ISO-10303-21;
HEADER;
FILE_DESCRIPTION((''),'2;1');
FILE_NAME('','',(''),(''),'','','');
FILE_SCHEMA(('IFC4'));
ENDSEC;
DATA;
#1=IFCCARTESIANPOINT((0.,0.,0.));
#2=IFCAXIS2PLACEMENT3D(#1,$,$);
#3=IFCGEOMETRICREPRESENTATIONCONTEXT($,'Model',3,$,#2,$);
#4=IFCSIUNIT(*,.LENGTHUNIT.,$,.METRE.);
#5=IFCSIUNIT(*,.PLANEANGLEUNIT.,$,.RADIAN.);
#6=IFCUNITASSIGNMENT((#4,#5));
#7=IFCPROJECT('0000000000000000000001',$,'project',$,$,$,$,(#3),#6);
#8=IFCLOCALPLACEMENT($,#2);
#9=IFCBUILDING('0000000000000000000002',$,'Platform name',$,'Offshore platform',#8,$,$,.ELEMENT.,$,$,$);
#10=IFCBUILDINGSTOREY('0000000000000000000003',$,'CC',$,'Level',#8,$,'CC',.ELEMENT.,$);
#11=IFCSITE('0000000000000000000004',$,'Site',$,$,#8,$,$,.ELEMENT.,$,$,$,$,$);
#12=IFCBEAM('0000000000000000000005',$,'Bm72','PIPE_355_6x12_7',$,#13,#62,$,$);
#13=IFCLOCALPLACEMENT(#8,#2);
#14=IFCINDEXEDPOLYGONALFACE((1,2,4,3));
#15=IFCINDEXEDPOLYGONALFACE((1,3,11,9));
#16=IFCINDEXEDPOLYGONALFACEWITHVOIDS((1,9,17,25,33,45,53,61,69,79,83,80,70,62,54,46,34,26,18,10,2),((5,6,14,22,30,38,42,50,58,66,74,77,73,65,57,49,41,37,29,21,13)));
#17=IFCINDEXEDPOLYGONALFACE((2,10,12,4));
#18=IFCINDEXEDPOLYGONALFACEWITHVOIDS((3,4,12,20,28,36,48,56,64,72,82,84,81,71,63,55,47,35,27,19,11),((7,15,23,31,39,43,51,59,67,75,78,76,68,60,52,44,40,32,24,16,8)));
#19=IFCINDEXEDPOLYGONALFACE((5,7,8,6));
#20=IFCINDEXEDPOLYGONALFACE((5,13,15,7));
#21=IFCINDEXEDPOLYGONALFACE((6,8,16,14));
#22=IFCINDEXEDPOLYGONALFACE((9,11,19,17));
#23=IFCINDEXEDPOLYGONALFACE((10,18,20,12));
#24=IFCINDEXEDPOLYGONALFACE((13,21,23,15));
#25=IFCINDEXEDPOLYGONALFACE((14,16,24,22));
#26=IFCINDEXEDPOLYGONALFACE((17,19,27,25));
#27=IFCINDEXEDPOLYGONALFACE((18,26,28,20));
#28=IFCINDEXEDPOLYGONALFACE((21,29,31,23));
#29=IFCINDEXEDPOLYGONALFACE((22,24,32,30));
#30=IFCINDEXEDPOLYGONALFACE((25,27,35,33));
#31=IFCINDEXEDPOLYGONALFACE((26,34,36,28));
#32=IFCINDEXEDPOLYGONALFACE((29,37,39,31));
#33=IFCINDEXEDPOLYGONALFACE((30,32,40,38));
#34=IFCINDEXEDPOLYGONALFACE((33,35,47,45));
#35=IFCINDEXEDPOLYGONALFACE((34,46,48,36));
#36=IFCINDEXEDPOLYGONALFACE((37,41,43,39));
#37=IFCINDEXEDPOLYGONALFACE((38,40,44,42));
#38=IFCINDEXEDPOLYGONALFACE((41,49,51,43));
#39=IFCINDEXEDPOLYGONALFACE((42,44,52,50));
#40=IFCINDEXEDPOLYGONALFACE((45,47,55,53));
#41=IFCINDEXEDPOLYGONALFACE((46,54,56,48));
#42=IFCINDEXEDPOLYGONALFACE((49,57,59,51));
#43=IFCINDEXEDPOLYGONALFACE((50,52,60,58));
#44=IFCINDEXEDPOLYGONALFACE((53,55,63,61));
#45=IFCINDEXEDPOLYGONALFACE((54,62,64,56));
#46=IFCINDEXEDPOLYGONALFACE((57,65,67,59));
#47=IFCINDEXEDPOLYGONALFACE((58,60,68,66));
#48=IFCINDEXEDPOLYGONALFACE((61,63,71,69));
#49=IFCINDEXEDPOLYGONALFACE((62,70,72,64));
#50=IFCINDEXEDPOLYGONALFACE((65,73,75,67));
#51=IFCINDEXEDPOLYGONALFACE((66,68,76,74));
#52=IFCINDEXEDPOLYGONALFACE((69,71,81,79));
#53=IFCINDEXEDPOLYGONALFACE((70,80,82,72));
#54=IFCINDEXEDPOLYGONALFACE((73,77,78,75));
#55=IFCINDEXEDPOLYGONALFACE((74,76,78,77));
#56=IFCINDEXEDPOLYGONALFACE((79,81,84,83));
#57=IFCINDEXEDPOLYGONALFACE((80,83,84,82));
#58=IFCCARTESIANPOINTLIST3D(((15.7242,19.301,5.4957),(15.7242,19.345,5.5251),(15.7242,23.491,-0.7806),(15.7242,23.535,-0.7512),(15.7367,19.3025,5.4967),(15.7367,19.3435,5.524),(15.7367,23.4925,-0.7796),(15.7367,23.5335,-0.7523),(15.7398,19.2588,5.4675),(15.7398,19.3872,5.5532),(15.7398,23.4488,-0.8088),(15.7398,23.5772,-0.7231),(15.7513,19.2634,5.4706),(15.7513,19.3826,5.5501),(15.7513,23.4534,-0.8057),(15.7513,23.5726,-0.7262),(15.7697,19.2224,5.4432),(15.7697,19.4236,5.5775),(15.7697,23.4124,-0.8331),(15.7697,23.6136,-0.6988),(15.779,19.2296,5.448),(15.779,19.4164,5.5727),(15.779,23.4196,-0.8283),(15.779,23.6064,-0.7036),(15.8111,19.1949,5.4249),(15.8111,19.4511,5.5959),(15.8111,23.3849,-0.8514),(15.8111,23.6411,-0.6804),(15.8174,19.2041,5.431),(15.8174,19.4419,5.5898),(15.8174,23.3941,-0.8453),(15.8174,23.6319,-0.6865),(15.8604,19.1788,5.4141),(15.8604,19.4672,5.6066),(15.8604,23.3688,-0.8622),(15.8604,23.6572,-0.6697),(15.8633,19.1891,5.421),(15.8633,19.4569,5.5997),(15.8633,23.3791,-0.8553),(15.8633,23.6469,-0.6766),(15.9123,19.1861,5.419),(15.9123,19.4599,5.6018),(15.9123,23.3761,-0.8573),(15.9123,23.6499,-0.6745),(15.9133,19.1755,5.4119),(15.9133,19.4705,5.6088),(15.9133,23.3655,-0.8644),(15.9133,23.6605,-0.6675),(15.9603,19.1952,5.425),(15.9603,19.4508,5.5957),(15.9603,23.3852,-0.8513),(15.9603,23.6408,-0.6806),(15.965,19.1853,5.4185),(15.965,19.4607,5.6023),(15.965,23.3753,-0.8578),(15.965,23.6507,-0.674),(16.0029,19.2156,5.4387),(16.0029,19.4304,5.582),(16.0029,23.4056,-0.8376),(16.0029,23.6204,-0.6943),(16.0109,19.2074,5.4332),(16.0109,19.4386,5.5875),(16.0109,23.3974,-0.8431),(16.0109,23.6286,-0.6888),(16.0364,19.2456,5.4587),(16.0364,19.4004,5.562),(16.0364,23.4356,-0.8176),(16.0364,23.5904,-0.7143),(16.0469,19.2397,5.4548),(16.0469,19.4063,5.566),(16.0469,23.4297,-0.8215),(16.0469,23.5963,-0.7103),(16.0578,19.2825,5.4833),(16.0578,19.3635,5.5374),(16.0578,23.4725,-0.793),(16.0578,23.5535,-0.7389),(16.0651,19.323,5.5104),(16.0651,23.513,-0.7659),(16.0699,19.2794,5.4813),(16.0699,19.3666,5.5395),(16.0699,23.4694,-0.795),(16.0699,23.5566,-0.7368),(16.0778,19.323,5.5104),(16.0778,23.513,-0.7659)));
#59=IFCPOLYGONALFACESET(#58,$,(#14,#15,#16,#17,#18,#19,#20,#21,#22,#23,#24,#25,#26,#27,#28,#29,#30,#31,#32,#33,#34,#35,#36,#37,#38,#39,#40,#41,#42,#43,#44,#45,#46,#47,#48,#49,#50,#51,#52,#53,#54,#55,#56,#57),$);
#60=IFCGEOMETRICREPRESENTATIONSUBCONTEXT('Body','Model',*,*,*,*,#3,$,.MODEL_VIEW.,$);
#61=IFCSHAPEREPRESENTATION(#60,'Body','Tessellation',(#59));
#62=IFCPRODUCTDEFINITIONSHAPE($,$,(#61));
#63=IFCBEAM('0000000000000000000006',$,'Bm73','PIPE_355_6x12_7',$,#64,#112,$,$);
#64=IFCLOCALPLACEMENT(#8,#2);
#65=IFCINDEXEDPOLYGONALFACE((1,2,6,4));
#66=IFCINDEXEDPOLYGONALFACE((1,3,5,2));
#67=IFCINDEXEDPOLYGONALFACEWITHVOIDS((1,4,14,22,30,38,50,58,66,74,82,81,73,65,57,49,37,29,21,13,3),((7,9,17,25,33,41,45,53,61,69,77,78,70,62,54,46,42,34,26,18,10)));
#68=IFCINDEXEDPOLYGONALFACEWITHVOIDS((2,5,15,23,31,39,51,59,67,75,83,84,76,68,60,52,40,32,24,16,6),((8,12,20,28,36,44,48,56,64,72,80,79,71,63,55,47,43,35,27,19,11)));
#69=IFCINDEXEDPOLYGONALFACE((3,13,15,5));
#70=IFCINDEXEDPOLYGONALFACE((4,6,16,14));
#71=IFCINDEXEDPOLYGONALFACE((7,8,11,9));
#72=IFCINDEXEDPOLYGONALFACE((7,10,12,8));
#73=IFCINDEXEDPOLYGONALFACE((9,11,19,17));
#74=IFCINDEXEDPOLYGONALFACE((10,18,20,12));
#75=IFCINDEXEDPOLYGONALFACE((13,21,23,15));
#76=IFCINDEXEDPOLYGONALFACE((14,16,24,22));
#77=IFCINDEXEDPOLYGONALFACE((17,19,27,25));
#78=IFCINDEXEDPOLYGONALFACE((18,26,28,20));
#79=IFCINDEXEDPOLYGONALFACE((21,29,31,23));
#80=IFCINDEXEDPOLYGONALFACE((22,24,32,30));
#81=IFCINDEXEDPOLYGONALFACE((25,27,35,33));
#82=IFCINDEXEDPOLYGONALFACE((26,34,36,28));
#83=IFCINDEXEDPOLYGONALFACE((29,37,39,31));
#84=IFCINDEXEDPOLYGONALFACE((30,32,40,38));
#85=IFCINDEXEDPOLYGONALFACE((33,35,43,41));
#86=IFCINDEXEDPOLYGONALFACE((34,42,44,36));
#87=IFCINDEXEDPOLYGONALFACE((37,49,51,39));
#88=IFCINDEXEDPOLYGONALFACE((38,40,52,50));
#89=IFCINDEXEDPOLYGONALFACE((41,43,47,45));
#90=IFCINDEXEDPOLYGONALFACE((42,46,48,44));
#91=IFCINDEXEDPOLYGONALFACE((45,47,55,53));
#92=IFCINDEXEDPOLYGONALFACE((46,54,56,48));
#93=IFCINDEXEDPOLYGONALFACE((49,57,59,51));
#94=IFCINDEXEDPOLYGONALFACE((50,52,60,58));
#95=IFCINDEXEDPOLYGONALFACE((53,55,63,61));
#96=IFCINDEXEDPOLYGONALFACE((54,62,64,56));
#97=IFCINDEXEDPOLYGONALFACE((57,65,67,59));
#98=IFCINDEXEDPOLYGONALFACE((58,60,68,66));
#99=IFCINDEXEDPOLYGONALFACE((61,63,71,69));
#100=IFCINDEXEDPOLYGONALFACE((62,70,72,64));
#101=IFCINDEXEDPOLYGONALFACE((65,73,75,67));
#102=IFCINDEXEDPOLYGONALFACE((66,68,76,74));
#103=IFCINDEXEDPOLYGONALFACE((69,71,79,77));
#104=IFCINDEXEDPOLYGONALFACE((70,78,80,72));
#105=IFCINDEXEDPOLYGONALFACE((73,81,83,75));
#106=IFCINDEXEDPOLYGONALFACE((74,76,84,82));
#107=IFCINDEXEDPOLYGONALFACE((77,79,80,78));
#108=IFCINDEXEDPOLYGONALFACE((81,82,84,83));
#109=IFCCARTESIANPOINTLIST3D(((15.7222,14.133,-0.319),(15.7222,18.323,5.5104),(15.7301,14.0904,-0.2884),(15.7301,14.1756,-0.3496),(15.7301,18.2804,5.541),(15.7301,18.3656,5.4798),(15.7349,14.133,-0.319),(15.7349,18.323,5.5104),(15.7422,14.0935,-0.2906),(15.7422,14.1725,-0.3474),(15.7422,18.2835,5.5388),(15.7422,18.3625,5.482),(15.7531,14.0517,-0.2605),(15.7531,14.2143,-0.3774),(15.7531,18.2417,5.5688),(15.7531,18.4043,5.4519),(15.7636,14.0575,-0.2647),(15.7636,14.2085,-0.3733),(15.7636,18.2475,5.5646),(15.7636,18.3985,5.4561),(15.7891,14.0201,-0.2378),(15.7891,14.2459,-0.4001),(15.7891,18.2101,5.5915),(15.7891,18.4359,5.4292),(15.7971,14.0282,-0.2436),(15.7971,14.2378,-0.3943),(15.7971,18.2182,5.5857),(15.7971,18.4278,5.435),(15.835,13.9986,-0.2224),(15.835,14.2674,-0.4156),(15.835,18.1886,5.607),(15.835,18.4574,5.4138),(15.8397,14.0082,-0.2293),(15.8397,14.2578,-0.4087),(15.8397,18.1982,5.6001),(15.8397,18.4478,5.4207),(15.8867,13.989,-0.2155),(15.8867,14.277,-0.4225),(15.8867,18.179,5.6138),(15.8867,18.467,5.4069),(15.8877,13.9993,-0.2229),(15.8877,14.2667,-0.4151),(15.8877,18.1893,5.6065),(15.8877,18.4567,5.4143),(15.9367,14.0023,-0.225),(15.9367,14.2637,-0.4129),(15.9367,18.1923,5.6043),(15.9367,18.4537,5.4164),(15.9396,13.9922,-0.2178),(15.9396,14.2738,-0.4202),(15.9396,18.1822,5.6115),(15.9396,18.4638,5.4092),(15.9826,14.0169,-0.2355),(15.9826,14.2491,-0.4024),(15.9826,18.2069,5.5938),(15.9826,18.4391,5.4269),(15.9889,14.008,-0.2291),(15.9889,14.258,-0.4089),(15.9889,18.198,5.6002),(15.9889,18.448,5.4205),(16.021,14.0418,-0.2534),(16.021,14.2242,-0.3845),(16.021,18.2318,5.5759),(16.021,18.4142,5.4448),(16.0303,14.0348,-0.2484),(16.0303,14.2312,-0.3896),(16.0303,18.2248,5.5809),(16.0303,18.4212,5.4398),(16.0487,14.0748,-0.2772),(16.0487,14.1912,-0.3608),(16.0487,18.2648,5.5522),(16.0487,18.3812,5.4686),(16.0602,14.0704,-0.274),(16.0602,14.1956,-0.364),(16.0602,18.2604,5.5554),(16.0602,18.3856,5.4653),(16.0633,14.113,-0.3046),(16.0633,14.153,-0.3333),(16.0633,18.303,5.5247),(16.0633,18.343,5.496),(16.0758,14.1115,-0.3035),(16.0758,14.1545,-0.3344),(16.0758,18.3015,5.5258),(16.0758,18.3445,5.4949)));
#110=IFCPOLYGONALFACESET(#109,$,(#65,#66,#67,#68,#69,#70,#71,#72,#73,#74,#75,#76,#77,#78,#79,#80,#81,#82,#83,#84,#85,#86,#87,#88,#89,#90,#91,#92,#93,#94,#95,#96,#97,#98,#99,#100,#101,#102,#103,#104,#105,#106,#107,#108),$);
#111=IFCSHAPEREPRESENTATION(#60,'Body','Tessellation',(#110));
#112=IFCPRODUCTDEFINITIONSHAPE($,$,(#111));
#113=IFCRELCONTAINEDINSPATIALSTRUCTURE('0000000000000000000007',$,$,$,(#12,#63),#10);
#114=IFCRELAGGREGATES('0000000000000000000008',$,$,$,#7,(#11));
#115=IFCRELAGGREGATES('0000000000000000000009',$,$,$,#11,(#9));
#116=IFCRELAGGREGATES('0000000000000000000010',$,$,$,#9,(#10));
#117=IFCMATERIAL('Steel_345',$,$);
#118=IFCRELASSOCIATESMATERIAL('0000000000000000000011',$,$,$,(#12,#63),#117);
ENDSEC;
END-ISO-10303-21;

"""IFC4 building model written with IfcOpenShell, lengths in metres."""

from ifc_helpers import new_model, si_unit, frame, origin, origin_2d, place, context, subcontext, project, spatial, hollow_circle, extrude, source, transform, mapped, material, element, save


model = new_model("IFC4")

# Units and contexts
model_context = context("Model", 3, world=origin())
body_context = subcontext(model_context, "Body", "Model", "MODEL_VIEW")
ifc_project = project(units=[si_unit("LENGTHUNIT", "METRE"), si_unit("PLANEANGLEUNIT", "RADIAN")], contexts=[model_context])

# Site, building, storey
placement_1 = place(None, origin())
site = spatial("IfcSite", under=ifc_project, at=placement_1, Name="Site", CompositionType="ELEMENT")
building = spatial("IfcBuilding", under=site, at=placement_1, Name="Platform name", ObjectType="Offshore platform", CompositionType="ELEMENT")
storey = spatial("IfcBuildingStorey", under=building, at=placement_1, Name="CC", ObjectType="Level", LongName="CC", CompositionType="ELEMENT")

# Beams
ifc_material = material(Name="Steel_345")
shared_shape_1 = source(origin(), body_context, "Body", "SweptSolid", [
    extrude(hollow_circle(Radius=0.1778, WallThickness=0.0127, at=origin_2d()), frame((0.0, 0.0, 0.0), z_axis=(0.0, -0.555232, 0.831695), x_axis=(1.0, 0.0, 0.0)), (0.0, 0.0, 1.0), 7.5464),
])
placement_2 = place(None, origin())
placement_3 = place(placement_2, origin())
placement_4 = place(placement_3, origin())
beam_1_placement = place(placement_4, frame((15.9, 23.513, -0.7659)))
element("IfcBeam", 1, at=beam_1_placement, inside=storey, material=ifc_material, Name="Bm72", Description="PIPE_355_6x12_7", context=body_context, shape_type="MappedRepresentation", body=[
    mapped(shared_shape_1, transform((0.0, 0.0, 0.0), scale=1.0)),
])
shared_shape_2 = source(origin(), body_context, "Body", "SweptSolid", [
    extrude(hollow_circle(Radius=0.1778, WallThickness=0.0127, at=origin_2d()), frame((0.0, 0.0, 0.0), z_axis=(0.0, 0.583651, 0.812005), x_axis=(-1.0, 0.0, 0.0)), (0.0, 0.0, 1.0), 7.179),
])
placement_5 = place(None, origin())
placement_6 = place(placement_5, origin())
placement_7 = place(placement_6, origin())
beam_2_placement = place(placement_7, frame((15.9, 14.133, -0.319)))
element("IfcBeam", 2, at=beam_2_placement, inside=storey, material=ifc_material, Name="Bm73", Description="PIPE_355_6x12_7", context=body_context, shape_type="MappedRepresentation", body=[
    mapped(shared_shape_2, transform((0.0, 0.0, 0.0), scale=1.0)),
])

save(model, "model.ifc")
